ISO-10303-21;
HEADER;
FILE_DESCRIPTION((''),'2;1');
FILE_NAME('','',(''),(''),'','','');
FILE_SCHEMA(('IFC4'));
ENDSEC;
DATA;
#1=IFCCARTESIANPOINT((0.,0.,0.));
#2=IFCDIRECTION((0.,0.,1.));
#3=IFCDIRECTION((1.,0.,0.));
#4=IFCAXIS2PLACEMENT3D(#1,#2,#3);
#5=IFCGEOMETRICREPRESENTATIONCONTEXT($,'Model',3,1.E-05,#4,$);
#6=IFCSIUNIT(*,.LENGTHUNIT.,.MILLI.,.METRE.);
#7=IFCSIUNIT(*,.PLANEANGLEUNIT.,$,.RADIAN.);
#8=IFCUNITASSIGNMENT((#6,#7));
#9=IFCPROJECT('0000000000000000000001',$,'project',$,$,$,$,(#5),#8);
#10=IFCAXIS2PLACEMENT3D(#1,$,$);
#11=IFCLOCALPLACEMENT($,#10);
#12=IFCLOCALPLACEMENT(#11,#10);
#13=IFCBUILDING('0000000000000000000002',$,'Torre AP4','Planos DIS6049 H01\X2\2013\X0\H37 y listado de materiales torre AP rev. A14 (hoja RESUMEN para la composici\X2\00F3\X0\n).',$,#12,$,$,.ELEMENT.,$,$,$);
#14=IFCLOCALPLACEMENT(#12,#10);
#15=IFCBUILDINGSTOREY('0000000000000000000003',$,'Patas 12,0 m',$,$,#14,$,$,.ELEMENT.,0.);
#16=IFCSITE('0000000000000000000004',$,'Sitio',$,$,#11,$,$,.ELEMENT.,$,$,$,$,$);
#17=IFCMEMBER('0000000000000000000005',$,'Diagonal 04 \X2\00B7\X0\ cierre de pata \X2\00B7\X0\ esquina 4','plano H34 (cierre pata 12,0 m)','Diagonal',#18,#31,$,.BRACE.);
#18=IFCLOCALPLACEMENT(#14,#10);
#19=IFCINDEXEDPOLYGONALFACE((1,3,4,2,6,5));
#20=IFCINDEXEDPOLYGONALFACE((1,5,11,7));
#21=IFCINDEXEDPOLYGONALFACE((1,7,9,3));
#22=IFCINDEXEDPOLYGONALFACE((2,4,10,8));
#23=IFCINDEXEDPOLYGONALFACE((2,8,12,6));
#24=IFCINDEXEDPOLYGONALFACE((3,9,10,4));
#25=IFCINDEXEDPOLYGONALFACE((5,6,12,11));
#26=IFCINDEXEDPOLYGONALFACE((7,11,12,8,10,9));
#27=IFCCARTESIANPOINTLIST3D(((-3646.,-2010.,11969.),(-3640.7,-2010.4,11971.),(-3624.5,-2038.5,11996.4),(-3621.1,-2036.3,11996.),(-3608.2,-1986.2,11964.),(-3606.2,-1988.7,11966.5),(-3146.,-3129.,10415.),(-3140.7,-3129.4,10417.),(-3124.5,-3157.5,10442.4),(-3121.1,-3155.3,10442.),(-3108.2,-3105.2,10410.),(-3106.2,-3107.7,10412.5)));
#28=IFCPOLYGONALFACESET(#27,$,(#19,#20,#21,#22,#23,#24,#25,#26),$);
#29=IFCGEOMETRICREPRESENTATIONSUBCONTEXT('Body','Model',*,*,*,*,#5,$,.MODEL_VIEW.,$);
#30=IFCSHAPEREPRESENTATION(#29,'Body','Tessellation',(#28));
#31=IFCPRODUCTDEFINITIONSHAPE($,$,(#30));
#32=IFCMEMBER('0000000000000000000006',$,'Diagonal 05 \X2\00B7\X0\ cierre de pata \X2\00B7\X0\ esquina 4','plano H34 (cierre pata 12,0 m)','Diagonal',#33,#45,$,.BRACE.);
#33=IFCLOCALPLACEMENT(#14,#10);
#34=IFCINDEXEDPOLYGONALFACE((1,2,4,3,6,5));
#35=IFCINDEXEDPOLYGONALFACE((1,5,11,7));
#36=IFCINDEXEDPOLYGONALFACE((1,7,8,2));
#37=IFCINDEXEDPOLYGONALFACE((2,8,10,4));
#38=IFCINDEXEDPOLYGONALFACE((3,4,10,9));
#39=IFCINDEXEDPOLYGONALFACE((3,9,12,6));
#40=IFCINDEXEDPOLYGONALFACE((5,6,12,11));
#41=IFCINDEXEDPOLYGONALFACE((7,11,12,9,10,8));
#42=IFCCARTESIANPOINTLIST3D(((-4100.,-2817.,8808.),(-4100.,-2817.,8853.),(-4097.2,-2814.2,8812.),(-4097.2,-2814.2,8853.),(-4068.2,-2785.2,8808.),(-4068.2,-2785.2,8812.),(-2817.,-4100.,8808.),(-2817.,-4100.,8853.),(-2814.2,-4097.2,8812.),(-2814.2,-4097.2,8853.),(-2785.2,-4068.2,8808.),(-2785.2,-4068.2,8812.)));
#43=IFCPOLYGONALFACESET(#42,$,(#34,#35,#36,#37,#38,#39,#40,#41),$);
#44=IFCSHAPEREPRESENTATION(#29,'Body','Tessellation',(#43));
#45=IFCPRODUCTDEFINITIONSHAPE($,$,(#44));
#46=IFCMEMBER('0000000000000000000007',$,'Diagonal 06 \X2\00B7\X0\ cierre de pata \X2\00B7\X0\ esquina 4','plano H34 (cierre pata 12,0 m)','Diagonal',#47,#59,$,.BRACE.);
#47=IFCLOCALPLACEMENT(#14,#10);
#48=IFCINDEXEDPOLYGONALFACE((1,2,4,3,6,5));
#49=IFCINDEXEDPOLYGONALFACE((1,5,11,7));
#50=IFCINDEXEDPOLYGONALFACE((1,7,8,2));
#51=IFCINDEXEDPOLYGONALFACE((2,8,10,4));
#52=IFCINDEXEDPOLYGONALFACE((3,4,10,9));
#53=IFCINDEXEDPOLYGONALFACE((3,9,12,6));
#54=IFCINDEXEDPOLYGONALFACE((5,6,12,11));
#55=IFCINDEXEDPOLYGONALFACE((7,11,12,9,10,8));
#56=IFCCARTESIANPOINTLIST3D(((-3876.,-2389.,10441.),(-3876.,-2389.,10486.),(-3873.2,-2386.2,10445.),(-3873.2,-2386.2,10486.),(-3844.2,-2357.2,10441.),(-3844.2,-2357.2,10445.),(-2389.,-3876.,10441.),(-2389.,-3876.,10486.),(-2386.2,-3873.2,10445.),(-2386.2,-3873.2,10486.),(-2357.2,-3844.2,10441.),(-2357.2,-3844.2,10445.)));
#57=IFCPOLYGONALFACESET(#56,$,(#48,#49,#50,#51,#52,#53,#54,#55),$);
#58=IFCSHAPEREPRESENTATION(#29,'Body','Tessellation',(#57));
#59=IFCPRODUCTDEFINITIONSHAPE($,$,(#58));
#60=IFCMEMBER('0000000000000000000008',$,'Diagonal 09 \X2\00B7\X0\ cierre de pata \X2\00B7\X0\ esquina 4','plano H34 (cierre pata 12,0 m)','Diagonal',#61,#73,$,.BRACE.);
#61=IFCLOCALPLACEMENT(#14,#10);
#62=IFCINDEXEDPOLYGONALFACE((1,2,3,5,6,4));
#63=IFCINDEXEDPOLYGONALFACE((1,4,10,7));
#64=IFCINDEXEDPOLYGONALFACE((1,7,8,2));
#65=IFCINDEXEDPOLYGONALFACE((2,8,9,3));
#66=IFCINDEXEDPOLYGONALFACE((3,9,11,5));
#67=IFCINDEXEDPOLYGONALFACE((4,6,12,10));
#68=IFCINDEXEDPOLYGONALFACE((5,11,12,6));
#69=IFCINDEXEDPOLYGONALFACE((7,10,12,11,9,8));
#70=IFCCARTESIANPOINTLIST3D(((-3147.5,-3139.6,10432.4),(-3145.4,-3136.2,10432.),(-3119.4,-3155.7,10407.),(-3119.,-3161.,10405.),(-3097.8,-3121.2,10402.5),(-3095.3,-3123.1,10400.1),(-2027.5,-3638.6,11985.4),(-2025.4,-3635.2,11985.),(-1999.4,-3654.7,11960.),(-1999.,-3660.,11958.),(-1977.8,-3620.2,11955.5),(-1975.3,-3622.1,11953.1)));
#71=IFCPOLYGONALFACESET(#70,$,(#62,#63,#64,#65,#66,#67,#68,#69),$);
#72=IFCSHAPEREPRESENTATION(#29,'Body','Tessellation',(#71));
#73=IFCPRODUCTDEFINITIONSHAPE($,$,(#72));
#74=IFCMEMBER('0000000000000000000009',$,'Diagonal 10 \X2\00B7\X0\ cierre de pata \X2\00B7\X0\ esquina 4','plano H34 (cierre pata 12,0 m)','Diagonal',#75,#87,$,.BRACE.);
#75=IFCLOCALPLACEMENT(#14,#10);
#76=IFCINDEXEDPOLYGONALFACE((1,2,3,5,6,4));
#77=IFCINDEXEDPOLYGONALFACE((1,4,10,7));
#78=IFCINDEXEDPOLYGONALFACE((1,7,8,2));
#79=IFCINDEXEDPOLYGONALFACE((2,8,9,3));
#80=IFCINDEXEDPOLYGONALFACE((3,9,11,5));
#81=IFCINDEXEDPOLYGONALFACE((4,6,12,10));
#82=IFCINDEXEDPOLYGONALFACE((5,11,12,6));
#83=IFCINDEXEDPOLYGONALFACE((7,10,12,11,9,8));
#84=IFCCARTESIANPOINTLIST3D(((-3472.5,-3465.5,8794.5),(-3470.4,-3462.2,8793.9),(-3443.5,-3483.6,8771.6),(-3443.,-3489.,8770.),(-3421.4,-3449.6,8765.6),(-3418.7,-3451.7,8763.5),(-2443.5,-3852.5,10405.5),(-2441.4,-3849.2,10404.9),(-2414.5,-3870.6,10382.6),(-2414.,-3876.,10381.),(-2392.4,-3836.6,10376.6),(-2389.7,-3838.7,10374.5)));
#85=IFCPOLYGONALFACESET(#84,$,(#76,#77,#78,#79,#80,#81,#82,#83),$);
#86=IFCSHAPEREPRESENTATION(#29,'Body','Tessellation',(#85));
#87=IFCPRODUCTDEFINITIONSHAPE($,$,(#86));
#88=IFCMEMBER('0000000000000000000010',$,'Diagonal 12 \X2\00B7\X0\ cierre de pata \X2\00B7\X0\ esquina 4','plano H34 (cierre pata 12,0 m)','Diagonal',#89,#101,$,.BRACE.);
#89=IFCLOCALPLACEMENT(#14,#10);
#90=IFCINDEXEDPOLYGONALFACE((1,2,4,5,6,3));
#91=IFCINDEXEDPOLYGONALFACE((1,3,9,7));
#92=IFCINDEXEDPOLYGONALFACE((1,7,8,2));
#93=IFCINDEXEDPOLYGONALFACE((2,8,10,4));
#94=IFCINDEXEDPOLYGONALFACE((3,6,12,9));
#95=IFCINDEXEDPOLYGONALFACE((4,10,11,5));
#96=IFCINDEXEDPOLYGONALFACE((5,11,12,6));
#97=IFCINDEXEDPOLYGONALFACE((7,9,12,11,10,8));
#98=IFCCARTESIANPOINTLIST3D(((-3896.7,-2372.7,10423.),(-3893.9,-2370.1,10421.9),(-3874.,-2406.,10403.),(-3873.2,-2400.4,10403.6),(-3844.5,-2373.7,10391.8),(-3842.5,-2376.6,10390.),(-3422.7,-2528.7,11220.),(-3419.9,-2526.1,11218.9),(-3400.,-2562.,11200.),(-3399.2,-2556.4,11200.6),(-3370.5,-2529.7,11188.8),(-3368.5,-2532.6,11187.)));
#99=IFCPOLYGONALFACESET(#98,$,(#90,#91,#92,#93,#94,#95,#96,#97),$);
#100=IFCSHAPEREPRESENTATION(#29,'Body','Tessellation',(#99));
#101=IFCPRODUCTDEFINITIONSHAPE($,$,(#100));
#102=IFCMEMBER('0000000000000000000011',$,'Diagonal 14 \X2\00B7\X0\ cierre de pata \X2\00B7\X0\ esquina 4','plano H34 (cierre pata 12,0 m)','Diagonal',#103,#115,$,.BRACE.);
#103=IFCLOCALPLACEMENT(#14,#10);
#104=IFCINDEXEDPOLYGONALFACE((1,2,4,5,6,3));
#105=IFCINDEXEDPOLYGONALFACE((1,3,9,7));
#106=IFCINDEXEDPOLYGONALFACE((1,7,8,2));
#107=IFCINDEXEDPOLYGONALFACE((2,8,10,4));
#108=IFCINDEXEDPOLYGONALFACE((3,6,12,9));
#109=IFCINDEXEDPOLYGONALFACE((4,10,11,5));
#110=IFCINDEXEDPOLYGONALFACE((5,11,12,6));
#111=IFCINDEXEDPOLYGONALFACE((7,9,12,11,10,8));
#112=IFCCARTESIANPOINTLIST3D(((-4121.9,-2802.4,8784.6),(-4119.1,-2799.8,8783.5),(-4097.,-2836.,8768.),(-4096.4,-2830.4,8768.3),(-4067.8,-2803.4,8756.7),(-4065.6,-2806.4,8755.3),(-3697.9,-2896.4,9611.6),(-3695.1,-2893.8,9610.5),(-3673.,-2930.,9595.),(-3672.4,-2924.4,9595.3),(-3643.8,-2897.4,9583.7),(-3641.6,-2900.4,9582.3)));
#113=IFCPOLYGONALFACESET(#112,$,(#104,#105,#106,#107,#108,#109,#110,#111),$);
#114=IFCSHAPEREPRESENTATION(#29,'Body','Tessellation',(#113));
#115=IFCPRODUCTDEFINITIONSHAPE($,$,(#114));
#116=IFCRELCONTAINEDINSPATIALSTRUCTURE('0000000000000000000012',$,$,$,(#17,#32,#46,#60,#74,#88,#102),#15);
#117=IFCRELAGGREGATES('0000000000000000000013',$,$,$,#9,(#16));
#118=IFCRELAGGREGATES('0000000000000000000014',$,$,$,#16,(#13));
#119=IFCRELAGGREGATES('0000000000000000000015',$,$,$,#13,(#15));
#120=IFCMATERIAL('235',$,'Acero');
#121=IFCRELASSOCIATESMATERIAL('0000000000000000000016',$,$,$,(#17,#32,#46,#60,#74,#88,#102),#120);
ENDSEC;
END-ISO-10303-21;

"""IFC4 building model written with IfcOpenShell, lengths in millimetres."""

from ifc_helpers import new_model, si_unit, frame, frame_2d, origin, origin_with_axes, place, context, subcontext, project, spatial, l_section, extrude, material, element, save


model = new_model("IFC4")

# Units and contexts
model_context = context("Model", 3, precision=1e-05, world=origin_with_axes())
body_context = subcontext(model_context, "Body", "Model", "MODEL_VIEW")
ifc_project = project(units=[si_unit("LENGTHUNIT", "METRE", prefix="MILLI"), si_unit("PLANEANGLEUNIT", "RADIAN")], contexts=[model_context])

# Site, building, storey
site_placement = place(None, origin())
site = spatial("IfcSite", under=ifc_project, at=site_placement, Name="Sitio", CompositionType="ELEMENT")
building_placement = place(site_placement, origin())
building = spatial("IfcBuilding", under=site, at=building_placement, Name="Torre AP4", Description="Planos DIS6049 H01–H37 y listado de materiales torre AP rev. A14 (hoja RESUMEN para la composición).", CompositionType="ELEMENT")
storey_placement = place(building_placement, origin())
storey = spatial("IfcBuildingStorey", under=building, at=storey_placement, Name="Patas 12,0 m", CompositionType="ELEMENT", Elevation=0.0)

# Members
ifc_material_1 = material(Name="235", Category="Acero")
member_1_placement = place(storey_placement, frame((-3646.0, -2010.0, 11969.0), z_axis=(0.252632, -0.565391, -0.785181), x_axis=(0.840989, 0.529594, -0.11076)))
element("IfcMember", 1, at=member_1_placement, inside=storey, material=ifc_material_1, Name="Diagonal 04 · cierre de pata · esquina 4", Description="plano H34 (cierre pata 12,0 m)", ObjectType="Diagonal", PredefinedType="BRACE", context=body_context, shape_type="SweptSolid", body=[
    extrude(l_section(Depth=45.0, Width=45.0, Thickness=4.0, at=frame_2d((22.5, 22.5))), None, (0.0, 0.0, 1.0), 1979.2),
])
member_2_placement = place(storey_placement, frame((-4100.0, -2817.0, 8808.0), z_axis=(0.707107, -0.707107, 0.0), x_axis=(0.707107, 0.707107, 0.0)))
element("IfcMember", 2, at=member_2_placement, inside=storey, material=ifc_material_1, Name="Diagonal 05 · cierre de pata · esquina 4", Description="plano H34 (cierre pata 12,0 m)", ObjectType="Diagonal", PredefinedType="BRACE", context=body_context, shape_type="SweptSolid", body=[
    extrude(l_section(Depth=45.0, Width=45.0, Thickness=4.0, at=frame_2d((22.5, 22.5))), None, (0.0, 0.0, 1.0), 1814.4),
])
member_3_placement = place(storey_placement, frame((-3876.0, -2389.0, 10441.0), z_axis=(0.707107, -0.707107, 0.0), x_axis=(0.707107, 0.707107, 0.0)))
element("IfcMember", 3, at=member_3_placement, inside=storey, material=ifc_material_1, Name="Diagonal 06 · cierre de pata · esquina 4", Description="plano H34 (cierre pata 12,0 m)", ObjectType="Diagonal", PredefinedType="BRACE", context=body_context, shape_type="SweptSolid", body=[
    extrude(l_section(Depth=45.0, Width=45.0, Thickness=4.0, at=frame_2d((22.5, 22.5))), None, (0.0, 0.0, 1.0), 2102.9),
])
member_4_placement = place(storey_placement, frame((-3119.0, -3161.0, 10405.0), z_axis=(0.566031, -0.252187, 0.784863), x_axis=(0.527101, 0.842737, -0.109355)))
element("IfcMember", 4, at=member_4_placement, inside=storey, material=ifc_material_1, Name="Diagonal 09 · cierre de pata · esquina 4", Description="plano H34 (cierre pata 12,0 m)", ObjectType="Diagonal", PredefinedType="BRACE", context=body_context, shape_type="SweptSolid", body=[
    extrude(l_section(Depth=45.0, Width=45.0, Thickness=4.0, at=frame_2d((22.5, 22.5))), None, (0.0, 0.0, 1.0), 1978.7),
])
member_5_placement = place(storey_placement, frame((-3443.0, -3489.0, 8770.0), z_axis=(0.527593, -0.198424, 0.825998), x_axis=(0.539245, 0.829544, -0.145158)))
element("IfcMember", 5, at=member_5_placement, inside=storey, material=ifc_material_1, Name="Diagonal 10 · cierre de pata · esquina 4", Description="plano H34 (cierre pata 12,0 m)", ObjectType="Diagonal", PredefinedType="BRACE", context=body_context, shape_type="SweptSolid", body=[
    extrude(l_section(Depth=45.0, Width=45.0, Thickness=4.0, at=frame_2d((22.5, 22.5))), None, (0.0, 0.0, 1.0), 1950.4),
])
member_6_placement = place(storey_placement, frame((-3874.0, -2406.0, 10403.0), z_axis=(0.504078, -0.165899, 0.847575), x_axis=(0.700597, 0.652429, -0.288964)))
element("IfcMember", 6, at=member_6_placement, inside=storey, material=ifc_material_1, Name="Diagonal 12 · cierre de pata · esquina 4", Description="plano H34 (cierre pata 12,0 m)", ObjectType="Diagonal", PredefinedType="BRACE", context=body_context, shape_type="SweptSolid", body=[
    extrude(l_section(Depth=45.0, Width=45.0, Thickness=4.0, at=frame_2d((22.5, 22.5))), None, (0.0, 0.0, 1.0), 940.3),
])
member_7_placement = place(storey_placement, frame((-4097.0, -2836.0, 8768.0), z_axis=(0.453913, -0.100632, 0.885345), x_axis=(0.697959, 0.657818, -0.283071)))
element("IfcMember", 7, at=member_7_placement, inside=storey, material=ifc_material_1, Name="Diagonal 14 · cierre de pata · esquina 4", Description="plano H34 (cierre pata 12,0 m)", ObjectType="Diagonal", PredefinedType="BRACE", context=body_context, shape_type="SweptSolid", body=[
    extrude(l_section(Depth=45.0, Width=45.0, Thickness=4.0, at=frame_2d((22.5, 22.5))), None, (0.0, 0.0, 1.0), 934.1),
])

save(model, "model.ifc")
